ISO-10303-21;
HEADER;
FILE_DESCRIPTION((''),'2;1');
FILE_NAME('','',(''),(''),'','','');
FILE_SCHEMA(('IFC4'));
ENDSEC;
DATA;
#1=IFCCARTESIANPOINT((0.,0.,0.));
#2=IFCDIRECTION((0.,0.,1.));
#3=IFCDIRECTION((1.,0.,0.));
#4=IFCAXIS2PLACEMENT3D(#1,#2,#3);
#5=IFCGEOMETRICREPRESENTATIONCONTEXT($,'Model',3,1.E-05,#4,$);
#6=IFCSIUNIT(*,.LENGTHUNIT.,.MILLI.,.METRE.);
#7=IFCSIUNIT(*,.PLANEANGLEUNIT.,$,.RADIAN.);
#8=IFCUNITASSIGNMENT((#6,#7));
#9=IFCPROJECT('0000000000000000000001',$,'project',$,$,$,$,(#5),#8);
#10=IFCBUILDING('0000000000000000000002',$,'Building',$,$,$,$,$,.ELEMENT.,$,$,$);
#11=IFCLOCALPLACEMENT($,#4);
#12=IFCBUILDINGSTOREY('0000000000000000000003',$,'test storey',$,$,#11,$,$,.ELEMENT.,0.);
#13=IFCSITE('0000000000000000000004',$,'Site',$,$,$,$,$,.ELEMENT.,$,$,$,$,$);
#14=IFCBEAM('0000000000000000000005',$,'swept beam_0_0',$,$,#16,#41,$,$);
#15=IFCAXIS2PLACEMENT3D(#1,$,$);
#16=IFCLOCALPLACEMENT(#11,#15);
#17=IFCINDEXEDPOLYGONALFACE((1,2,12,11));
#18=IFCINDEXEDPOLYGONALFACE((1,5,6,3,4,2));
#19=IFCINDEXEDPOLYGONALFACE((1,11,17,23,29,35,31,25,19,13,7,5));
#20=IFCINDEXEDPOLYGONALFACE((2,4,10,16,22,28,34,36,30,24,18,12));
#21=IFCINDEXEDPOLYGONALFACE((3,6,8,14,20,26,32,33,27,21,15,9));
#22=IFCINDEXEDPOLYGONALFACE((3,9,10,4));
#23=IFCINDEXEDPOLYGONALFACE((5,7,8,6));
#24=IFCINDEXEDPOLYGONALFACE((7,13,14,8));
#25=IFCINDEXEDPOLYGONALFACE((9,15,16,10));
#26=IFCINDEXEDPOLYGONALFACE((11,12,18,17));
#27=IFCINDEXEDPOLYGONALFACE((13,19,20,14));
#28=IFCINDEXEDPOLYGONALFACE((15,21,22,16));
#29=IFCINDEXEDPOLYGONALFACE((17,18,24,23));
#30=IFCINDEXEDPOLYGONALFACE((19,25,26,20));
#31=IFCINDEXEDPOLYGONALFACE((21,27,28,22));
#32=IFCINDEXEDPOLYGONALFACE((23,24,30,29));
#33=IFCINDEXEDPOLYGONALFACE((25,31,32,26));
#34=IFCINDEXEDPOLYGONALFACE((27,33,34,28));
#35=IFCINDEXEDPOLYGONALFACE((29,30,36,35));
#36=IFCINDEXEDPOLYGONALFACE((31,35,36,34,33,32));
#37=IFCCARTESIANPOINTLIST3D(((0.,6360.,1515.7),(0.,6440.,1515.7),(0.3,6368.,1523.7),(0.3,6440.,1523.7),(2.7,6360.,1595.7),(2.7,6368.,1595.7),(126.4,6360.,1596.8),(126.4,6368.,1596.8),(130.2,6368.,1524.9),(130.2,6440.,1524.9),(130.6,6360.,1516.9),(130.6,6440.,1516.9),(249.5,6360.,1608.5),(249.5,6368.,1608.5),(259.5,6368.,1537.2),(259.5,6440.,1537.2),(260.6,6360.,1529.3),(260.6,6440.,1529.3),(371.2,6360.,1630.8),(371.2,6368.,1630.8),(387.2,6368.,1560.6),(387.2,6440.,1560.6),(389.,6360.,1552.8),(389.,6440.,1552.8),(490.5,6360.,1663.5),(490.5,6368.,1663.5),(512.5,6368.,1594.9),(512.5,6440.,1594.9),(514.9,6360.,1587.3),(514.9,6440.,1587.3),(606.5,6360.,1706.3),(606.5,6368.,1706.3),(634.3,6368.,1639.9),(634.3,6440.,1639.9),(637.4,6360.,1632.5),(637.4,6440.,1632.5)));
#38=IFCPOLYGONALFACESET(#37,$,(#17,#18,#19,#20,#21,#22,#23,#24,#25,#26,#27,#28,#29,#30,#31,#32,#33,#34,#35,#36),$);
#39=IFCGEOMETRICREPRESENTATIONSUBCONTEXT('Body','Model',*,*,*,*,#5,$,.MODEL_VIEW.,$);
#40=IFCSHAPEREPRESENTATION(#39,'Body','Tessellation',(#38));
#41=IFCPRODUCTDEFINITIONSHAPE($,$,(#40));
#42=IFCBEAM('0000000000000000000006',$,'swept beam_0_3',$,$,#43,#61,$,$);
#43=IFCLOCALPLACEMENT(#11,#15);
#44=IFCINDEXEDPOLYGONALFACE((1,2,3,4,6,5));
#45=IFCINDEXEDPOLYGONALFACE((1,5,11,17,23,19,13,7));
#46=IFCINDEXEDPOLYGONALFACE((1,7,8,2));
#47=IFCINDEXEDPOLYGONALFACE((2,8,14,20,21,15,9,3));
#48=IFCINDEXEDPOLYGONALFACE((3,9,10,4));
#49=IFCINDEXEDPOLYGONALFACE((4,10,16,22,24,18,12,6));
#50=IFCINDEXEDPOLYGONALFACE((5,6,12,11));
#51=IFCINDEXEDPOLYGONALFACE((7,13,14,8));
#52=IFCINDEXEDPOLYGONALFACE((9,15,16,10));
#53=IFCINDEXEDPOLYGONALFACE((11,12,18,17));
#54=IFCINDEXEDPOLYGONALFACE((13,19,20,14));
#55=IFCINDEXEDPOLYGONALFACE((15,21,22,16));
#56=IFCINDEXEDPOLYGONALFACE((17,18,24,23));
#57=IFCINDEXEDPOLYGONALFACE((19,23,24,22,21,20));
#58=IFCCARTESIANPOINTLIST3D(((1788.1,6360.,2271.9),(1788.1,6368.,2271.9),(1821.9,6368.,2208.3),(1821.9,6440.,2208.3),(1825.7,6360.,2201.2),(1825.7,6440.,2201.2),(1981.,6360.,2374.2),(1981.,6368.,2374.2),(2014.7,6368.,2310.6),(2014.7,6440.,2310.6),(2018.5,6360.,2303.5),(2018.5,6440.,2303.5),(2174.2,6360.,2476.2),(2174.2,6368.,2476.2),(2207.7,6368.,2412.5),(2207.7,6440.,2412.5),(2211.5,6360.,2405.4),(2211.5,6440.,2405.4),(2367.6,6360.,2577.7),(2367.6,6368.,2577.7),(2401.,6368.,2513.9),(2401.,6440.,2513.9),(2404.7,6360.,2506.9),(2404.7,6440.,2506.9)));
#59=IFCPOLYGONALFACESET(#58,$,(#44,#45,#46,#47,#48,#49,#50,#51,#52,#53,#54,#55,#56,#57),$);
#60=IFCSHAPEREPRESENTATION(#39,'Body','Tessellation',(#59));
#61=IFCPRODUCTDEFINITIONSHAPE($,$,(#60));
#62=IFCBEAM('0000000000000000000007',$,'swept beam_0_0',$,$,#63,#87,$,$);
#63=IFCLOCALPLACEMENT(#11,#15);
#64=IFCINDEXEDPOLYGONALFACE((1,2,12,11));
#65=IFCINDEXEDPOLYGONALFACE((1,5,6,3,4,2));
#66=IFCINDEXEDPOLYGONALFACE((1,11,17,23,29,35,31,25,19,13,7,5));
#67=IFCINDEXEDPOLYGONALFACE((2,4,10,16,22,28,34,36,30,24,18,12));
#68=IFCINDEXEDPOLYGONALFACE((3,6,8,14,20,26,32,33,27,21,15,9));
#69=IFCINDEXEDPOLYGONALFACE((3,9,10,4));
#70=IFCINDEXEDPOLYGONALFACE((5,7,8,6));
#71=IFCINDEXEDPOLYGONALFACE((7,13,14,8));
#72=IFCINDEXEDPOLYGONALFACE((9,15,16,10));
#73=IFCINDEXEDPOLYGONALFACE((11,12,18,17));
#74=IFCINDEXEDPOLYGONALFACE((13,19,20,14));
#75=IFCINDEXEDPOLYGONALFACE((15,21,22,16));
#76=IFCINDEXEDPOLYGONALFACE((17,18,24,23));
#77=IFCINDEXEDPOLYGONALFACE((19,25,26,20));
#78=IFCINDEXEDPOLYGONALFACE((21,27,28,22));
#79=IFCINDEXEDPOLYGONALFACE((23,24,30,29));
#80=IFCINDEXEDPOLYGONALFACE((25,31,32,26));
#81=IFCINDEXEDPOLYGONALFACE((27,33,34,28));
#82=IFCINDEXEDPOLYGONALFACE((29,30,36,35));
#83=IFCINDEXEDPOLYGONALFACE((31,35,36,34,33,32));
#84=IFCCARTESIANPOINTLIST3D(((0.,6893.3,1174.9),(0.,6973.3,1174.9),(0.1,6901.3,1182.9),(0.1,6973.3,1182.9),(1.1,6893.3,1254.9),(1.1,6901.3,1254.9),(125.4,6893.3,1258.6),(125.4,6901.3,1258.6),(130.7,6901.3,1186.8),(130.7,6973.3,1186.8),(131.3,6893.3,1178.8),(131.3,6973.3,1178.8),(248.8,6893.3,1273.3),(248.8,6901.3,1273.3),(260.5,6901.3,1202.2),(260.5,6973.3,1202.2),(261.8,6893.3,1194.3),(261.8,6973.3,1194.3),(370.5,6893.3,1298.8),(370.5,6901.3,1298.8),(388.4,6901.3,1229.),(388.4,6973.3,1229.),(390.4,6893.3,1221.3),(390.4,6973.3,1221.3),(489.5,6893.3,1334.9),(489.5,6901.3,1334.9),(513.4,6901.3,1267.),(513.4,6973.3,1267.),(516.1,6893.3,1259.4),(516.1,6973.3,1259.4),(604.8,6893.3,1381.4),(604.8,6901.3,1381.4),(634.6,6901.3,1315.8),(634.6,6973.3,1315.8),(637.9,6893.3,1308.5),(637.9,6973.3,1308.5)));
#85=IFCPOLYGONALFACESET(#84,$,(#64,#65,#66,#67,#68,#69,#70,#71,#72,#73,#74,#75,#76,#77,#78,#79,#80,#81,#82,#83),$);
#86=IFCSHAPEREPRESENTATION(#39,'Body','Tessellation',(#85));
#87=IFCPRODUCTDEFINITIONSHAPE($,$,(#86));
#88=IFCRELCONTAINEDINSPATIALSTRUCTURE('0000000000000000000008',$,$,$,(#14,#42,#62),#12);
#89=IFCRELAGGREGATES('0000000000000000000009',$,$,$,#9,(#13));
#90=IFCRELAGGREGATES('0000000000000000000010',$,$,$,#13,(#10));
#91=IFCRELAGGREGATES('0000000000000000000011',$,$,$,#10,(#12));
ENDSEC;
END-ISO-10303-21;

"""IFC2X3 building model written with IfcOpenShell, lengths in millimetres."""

from ifc_helpers import new_model, entity, si_unit, origin_with_axes, place, context, subcontext, project, spatial, element, save


model = new_model("IFC2X3")

# Units and contexts
model_context = context("Model", 3, precision=1e-05, world=origin_with_axes())
body_context = subcontext(model_context, "Body", "Model", "MODEL_VIEW")
ifc_project = project(units=[si_unit("LENGTHUNIT", "METRE", prefix="MILLI"), si_unit("PLANEANGLEUNIT", "RADIAN")], contexts=[model_context])

# Site, building, storey
site = spatial("IfcSite", under=ifc_project, Name="Site", CompositionType="ELEMENT")
building = spatial("IfcBuilding", under=site, Name="Building", CompositionType="ELEMENT")
storey_placement = place(None, origin_with_axes())
storey = spatial("IfcBuildingStorey", under=building, at=storey_placement, Name="test storey", CompositionType="ELEMENT", Elevation=0.0)

# Beams
beam_1_placement = place(storey_placement, origin_with_axes())
element("IfcBeam", 1, at=beam_1_placement, inside=storey, Name="swept beam_0_0", context=body_context, shape_type="SweptSolid", body=[
    entity("IfcRevolvedAreaSolid", entity("IfcArbitraryClosedProfileDef", "AREA", None, entity("IfcPolyline", [entity("IfcCartesianPoint", [-80.0, 40.0]), entity("IfcCartesianPoint", [-80.0, 32.0]), entity("IfcCartesianPoint", [-8.0, 32.0]), entity("IfcCartesianPoint", [-8.0, -40.0]), entity("IfcCartesianPoint", [0.0, -40.0]), entity("IfcCartesianPoint", [0.0, 40.0]), entity("IfcCartesianPoint", [-80.0, 40.0])])), entity("IfcAxis2Placement3D", entity("IfcCartesianPoint", [0.0, 6400.0, 1515.7]), entity("IfcDirection", [-0.9994, 0.0, 0.0341]), entity("IfcDirection", [-0.0341, 0.0, -0.9994])), entity("IfcAxis1Placement", entity("IfcCartesianPoint", [-1516.6, 0.0, 0.0]), entity("IfcDirection", [0.0, 1.0, 0.0])), 0.430608),
])
beam_2_placement = place(storey_placement, origin_with_axes())
element("IfcBeam", 2, at=beam_2_placement, inside=storey, Name="swept beam_0_3", context=body_context, shape_type="SweptSolid", body=[
    entity("IfcRevolvedAreaSolid", entity("IfcArbitraryClosedProfileDef", "AREA", None, entity("IfcPolyline", [entity("IfcCartesianPoint", [80.0, -40.0]), entity("IfcCartesianPoint", [80.0, -32.0]), entity("IfcCartesianPoint", [8.0, -32.0]), entity("IfcCartesianPoint", [8.0, 40.0]), entity("IfcCartesianPoint", [0.0, 40.0]), entity("IfcCartesianPoint", [0.0, -40.0]), entity("IfcCartesianPoint", [80.0, -40.0])])), entity("IfcAxis2Placement3D", entity("IfcCartesianPoint", [1825.7, 6400.0, 2201.2]), entity("IfcDirection", [-0.8828, 0.0, -0.4697]), entity("IfcDirection", [-0.4697, 0.0, 0.8828])), entity("IfcAxis1Placement", entity("IfcCartesianPoint", [-99820.0, 0.0, 0.0]), entity("IfcDirection", [0.0, 1.0, 0.0])), 0.006559),
])
beam_3_placement = place(storey_placement, origin_with_axes())
element("IfcBeam", 3, at=beam_3_placement, inside=storey, Name="swept beam_0_0", context=body_context, shape_type="SweptSolid", body=[
    entity("IfcRevolvedAreaSolid", entity("IfcArbitraryClosedProfileDef", "AREA", None, entity("IfcPolyline", [entity("IfcCartesianPoint", [-80.0, 40.0]), entity("IfcCartesianPoint", [-80.0, 32.0]), entity("IfcCartesianPoint", [-8.0, 32.0]), entity("IfcCartesianPoint", [-8.0, -40.0]), entity("IfcCartesianPoint", [0.0, -40.0]), entity("IfcCartesianPoint", [0.0, 40.0]), entity("IfcCartesianPoint", [-80.0, 40.0])])), entity("IfcAxis2Placement3D", entity("IfcCartesianPoint", [0.0, 6933.3, 1174.9]), entity("IfcDirection", [-0.9999, 0.0, 0.0142]), entity("IfcDirection", [-0.0142, 0.0, -0.9999])), entity("IfcAxis1Placement", entity("IfcCartesianPoint", [-1488.3, 0.0, 0.0]), entity("IfcDirection", [0.0, 1.0, 0.0])), 0.441503),
])

save(model, "model.ifc")
